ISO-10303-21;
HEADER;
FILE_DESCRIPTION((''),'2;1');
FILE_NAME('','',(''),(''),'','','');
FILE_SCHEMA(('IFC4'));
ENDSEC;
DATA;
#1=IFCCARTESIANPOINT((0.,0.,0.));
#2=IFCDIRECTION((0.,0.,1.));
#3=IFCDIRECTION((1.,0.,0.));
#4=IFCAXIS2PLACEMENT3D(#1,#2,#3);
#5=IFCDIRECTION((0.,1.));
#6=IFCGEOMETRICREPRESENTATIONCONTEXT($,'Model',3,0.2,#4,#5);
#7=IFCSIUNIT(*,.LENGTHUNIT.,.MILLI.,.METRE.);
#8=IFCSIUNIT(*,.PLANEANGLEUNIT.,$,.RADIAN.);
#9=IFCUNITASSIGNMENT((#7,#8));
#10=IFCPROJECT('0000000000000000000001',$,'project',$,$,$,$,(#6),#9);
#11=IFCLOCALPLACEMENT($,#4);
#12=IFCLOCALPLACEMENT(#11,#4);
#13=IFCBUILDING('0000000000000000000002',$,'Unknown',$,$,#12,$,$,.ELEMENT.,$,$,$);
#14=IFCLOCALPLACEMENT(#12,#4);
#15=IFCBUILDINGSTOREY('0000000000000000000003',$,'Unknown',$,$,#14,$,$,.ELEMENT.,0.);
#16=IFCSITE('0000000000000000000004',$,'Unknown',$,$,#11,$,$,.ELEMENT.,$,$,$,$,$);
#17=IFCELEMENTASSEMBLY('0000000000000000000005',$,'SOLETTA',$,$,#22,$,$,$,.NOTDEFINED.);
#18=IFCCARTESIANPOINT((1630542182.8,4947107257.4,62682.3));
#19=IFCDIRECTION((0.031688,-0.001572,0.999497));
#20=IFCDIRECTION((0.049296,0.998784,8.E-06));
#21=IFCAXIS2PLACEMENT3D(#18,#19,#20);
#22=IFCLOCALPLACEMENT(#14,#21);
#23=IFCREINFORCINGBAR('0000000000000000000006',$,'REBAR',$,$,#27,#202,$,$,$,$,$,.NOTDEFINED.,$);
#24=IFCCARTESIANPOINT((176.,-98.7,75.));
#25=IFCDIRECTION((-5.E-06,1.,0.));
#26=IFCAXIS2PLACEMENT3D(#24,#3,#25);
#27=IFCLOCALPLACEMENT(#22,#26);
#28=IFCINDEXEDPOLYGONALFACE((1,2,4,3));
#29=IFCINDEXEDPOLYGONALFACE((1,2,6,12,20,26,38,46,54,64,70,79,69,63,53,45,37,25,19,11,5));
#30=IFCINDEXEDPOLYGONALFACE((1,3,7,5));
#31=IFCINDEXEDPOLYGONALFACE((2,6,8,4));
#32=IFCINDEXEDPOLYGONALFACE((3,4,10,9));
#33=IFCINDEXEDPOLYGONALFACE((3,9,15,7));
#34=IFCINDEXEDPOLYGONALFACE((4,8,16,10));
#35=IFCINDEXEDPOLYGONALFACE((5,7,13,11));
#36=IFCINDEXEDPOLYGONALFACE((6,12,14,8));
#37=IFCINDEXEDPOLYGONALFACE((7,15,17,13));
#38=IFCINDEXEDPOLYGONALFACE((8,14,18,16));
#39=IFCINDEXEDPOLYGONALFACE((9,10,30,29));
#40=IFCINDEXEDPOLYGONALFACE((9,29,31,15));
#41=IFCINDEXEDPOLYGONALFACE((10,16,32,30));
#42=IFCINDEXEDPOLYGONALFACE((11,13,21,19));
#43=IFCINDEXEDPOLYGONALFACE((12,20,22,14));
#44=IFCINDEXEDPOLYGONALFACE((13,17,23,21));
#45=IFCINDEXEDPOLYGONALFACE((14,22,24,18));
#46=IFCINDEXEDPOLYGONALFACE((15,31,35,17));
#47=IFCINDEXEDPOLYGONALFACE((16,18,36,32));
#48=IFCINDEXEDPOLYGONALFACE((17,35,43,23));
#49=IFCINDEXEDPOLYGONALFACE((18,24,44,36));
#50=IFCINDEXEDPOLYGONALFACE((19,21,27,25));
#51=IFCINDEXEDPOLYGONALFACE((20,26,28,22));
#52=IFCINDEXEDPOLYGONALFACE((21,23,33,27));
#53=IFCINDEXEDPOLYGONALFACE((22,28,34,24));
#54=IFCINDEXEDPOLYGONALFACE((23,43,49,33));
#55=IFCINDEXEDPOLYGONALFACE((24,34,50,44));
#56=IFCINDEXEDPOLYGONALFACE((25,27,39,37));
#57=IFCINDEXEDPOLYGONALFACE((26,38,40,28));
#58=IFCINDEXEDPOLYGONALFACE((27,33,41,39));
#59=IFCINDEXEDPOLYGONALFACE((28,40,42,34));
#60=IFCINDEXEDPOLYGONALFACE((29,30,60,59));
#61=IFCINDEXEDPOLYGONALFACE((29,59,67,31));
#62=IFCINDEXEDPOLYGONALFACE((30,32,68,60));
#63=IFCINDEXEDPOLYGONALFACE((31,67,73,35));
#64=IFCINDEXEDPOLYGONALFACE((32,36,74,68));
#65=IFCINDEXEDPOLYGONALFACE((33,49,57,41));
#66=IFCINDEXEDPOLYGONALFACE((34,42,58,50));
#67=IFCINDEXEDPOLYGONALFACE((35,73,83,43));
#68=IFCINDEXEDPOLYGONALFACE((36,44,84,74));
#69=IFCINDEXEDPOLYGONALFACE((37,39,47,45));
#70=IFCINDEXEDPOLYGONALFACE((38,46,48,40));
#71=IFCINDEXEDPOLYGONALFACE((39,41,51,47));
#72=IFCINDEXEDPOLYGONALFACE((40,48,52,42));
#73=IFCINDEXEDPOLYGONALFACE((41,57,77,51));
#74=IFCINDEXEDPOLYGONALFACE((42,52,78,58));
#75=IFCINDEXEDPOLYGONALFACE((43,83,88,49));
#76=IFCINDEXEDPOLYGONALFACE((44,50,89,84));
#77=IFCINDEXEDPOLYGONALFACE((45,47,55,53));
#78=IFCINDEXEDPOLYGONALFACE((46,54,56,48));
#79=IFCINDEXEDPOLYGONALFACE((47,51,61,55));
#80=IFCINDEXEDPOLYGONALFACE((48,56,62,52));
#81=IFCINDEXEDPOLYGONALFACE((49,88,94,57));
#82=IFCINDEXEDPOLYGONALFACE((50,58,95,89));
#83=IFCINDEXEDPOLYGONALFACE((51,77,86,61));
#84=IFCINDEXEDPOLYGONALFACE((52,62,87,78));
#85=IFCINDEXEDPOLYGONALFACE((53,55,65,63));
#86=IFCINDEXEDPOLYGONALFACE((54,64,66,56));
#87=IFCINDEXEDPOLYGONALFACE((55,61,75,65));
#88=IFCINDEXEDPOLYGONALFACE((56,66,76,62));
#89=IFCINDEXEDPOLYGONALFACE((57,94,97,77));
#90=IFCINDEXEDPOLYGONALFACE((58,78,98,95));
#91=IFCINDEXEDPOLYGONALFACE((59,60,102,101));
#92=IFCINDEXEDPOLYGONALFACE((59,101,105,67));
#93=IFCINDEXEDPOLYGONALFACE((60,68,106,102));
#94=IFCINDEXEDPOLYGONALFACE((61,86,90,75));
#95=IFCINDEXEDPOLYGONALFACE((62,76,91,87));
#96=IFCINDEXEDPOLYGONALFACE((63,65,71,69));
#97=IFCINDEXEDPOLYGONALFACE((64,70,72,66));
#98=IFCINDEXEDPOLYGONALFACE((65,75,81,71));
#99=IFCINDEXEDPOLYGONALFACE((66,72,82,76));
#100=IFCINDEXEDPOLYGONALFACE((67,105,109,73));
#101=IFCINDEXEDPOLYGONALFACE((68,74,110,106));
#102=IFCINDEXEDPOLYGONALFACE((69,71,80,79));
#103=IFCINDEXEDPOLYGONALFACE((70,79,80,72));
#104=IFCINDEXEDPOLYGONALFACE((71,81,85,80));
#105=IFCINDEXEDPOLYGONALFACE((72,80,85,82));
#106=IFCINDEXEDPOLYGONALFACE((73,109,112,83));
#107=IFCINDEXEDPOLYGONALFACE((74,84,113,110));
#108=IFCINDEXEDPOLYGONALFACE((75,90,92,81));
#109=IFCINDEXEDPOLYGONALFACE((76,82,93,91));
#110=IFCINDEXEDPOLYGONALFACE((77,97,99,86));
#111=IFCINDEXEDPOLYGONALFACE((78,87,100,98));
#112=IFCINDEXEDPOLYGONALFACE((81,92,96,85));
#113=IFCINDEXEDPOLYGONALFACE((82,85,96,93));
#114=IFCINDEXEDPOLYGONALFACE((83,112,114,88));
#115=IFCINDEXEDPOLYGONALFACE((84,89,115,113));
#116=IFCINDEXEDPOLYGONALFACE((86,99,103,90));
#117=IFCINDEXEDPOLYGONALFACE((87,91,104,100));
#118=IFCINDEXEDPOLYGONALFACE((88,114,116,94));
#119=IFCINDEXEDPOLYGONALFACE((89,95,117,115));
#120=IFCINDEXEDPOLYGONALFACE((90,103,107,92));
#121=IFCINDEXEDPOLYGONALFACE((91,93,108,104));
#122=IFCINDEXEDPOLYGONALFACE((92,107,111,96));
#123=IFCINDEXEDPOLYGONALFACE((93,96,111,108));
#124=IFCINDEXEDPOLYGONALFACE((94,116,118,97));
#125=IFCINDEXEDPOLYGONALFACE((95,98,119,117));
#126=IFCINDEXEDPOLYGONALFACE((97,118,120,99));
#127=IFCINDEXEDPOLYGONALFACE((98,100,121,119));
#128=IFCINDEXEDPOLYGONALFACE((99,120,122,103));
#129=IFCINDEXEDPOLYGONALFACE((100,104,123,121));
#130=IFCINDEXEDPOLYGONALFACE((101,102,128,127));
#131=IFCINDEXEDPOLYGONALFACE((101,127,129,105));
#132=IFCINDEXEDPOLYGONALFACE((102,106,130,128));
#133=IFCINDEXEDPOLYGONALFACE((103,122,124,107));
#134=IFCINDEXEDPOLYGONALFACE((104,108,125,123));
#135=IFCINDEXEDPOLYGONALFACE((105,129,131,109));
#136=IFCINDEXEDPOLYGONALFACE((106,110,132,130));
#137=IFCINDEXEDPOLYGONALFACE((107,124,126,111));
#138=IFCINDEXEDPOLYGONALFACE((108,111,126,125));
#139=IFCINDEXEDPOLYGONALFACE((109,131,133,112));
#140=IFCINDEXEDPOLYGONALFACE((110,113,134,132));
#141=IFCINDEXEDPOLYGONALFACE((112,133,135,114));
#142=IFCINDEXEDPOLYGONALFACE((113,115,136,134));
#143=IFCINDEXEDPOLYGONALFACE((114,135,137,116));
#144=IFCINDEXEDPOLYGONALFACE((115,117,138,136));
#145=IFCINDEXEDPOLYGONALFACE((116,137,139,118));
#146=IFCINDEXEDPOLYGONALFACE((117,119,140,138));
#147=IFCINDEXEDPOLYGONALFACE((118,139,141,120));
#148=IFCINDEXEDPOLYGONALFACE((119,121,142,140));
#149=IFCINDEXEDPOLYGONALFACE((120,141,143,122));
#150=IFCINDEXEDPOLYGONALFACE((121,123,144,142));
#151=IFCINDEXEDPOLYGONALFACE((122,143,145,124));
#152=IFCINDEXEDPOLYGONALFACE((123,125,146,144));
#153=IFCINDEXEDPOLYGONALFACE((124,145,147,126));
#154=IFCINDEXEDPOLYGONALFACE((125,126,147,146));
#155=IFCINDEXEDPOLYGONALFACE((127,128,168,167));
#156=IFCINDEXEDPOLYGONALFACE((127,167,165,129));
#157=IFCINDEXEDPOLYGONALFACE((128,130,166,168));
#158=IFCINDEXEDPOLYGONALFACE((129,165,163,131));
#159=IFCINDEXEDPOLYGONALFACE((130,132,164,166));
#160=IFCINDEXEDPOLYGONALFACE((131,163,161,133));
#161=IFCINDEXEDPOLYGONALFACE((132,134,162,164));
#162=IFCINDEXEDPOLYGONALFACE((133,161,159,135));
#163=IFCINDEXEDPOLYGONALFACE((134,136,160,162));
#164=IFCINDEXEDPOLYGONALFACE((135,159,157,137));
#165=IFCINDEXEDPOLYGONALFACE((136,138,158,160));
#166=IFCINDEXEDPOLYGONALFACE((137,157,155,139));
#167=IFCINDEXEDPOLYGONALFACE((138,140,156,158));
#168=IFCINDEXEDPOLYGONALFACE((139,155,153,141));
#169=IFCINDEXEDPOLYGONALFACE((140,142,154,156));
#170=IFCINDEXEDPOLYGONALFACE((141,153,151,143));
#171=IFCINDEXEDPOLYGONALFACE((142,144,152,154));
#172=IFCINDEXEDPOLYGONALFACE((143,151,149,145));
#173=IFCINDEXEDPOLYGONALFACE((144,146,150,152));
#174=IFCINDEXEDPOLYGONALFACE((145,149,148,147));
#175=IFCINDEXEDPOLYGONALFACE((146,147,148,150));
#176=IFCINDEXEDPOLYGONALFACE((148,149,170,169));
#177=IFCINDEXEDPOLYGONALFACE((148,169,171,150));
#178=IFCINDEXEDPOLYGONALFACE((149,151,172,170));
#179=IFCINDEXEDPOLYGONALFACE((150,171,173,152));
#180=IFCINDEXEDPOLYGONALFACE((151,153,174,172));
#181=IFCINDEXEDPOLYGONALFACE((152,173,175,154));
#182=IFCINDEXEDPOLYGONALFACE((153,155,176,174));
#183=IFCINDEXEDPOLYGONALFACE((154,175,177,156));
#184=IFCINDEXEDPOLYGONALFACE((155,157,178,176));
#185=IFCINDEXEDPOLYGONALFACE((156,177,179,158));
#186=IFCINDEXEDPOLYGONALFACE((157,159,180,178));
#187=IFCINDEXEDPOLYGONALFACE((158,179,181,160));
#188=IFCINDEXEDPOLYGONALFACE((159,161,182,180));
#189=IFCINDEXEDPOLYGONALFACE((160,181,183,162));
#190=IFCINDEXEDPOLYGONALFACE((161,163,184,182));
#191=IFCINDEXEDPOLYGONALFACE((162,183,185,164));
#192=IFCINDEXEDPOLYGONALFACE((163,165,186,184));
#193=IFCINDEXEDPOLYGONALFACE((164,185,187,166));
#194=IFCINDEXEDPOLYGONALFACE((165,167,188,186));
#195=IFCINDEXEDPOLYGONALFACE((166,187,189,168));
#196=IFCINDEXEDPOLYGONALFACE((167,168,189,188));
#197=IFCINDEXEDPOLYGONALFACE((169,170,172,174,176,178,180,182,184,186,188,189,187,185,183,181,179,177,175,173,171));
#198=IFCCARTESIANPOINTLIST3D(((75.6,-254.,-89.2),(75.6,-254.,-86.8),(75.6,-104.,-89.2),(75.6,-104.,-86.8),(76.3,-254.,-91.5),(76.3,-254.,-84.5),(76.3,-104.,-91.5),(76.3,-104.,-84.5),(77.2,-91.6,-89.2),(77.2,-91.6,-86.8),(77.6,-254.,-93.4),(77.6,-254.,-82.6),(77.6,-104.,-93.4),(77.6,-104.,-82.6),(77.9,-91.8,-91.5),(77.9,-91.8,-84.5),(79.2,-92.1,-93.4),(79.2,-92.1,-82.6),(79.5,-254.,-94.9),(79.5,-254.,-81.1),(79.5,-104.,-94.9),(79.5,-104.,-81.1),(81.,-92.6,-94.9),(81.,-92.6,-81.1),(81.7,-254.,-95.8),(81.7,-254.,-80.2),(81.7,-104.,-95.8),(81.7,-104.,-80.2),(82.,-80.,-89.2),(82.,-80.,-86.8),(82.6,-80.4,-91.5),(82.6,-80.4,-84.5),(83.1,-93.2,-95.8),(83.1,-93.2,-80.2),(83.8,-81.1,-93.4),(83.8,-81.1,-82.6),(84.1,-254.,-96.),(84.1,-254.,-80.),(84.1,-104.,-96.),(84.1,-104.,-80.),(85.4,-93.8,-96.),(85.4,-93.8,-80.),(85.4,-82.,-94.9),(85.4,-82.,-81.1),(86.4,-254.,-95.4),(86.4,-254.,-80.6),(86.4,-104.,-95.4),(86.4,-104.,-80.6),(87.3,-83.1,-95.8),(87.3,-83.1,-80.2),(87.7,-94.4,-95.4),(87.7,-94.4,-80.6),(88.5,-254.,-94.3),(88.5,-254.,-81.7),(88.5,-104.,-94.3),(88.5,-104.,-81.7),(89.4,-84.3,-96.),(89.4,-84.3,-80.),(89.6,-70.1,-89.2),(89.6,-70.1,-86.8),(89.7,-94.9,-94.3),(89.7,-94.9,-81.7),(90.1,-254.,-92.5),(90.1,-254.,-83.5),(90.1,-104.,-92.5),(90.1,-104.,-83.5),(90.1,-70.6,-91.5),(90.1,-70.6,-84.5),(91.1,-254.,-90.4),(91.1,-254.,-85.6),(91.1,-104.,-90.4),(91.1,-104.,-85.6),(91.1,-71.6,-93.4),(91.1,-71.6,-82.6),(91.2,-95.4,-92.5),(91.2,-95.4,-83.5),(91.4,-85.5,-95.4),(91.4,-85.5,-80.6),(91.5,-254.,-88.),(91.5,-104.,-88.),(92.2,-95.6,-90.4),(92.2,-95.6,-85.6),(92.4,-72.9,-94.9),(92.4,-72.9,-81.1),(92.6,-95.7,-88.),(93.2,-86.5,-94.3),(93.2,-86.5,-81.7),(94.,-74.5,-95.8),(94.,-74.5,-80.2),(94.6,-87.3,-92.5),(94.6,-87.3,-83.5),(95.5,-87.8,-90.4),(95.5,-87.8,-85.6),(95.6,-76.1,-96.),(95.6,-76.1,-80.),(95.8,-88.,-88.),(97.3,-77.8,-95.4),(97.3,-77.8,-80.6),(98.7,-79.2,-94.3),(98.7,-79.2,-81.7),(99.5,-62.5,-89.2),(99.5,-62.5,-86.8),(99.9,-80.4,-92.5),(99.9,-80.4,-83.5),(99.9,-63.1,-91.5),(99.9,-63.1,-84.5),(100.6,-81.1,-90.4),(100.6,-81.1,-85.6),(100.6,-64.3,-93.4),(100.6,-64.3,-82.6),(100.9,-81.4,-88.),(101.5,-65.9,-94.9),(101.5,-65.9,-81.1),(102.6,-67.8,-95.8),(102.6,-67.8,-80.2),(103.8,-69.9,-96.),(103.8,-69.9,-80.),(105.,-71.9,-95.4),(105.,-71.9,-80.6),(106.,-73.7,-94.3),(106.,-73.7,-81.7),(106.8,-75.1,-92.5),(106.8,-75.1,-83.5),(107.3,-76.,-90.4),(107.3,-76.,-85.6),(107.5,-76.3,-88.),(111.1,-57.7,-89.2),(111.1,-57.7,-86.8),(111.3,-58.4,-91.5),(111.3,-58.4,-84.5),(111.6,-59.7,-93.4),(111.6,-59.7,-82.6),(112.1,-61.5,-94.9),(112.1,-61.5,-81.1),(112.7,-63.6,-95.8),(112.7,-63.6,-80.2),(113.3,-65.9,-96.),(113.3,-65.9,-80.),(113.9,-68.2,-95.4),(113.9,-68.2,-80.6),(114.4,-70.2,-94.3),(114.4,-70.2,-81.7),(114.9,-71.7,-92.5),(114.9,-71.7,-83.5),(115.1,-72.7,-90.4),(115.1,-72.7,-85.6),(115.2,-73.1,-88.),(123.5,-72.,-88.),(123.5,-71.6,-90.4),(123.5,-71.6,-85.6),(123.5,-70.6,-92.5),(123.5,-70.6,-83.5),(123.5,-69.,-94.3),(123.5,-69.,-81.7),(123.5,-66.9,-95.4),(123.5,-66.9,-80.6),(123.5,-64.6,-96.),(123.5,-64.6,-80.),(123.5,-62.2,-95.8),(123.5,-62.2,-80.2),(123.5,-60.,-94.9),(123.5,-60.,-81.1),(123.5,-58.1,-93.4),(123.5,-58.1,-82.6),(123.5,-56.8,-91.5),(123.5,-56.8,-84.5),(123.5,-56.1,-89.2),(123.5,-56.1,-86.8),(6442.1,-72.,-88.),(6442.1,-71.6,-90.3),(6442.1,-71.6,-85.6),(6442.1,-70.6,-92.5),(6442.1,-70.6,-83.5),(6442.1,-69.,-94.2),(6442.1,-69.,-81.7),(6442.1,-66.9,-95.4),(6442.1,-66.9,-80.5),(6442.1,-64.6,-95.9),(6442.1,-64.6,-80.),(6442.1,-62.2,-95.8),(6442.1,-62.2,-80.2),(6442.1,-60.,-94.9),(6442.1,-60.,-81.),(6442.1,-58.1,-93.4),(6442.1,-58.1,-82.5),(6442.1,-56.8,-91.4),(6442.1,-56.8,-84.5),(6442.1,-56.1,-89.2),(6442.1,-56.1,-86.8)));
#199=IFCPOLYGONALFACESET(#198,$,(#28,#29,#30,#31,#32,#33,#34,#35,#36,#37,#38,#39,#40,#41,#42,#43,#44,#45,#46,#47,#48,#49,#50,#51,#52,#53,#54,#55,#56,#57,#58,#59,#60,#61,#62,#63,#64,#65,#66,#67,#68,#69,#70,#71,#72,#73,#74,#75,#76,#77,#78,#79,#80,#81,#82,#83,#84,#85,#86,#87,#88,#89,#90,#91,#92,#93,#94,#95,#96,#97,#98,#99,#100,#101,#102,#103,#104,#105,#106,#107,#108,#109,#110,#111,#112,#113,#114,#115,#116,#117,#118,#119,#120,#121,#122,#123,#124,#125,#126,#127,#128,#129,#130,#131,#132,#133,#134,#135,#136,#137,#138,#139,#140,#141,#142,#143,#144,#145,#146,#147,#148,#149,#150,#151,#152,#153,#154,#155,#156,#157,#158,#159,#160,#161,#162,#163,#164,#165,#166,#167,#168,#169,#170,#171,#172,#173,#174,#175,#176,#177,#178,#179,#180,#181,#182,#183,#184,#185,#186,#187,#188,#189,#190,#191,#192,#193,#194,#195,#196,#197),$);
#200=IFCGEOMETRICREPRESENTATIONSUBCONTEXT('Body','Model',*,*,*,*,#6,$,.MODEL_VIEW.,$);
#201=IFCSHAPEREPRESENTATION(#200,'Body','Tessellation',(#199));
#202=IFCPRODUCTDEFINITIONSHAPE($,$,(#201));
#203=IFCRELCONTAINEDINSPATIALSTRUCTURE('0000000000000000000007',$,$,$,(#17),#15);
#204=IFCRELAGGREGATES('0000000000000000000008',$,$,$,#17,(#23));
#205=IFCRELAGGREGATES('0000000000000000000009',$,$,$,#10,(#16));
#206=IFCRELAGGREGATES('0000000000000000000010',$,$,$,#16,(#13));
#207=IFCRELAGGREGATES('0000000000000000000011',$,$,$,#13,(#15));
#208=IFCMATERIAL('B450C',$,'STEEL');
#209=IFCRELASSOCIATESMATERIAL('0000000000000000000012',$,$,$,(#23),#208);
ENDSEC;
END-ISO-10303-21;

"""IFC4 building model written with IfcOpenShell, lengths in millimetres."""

from ifc_helpers import new_model, entity, si_unit, direction, frame, origin_with_axes, place, context, subcontext, project, spatial, material, element, aggregate, save


model = new_model("IFC4")

# Units and contexts
model_context = context("Model", 3, precision=0.2, world=origin_with_axes(), true_north=direction((0.0, 1.0)))
body_context = subcontext(model_context, "Body", "Model", "MODEL_VIEW")
ifc_project = project(units=[si_unit("LENGTHUNIT", "METRE", prefix="MILLI"), si_unit("PLANEANGLEUNIT", "RADIAN")], contexts=[model_context])

# Site, building, storey
site_placement = place(None, origin_with_axes())
site = spatial("IfcSite", under=ifc_project, at=site_placement, Name="Unknown", CompositionType="ELEMENT")
building_placement = place(site_placement, origin_with_axes())
building = spatial("IfcBuilding", under=site, at=building_placement, Name="Unknown", CompositionType="ELEMENT")
storey_placement = place(building_placement, origin_with_axes())
storey = spatial("IfcBuildingStorey", under=building, at=storey_placement, Name="Unknown", CompositionType="ELEMENT", Elevation=0.0)

# Element assembly, reinforcing bar
ifc_material = material(Name="B450C", Category="STEEL")
assembly_1_placement = place(storey_placement, frame((1630542182.8, 4947107257.4, 62682.3), z_axis=(0.031688, -0.001572, 0.999497), x_axis=(0.049296, 0.998784, 0.000008)))
assembly_1 = element("IfcElementAssembly", 1, at=assembly_1_placement, inside=storey, Name="SOLETTA", PredefinedType="NOTDEFINED")
reinforcing_bar_1_placement = place(assembly_1_placement, frame((176.0, -98.7, 75.0), z_axis=(1.0, 0.0, 0.0), x_axis=(-0.000005, 1.0, 0.0)))
reinforcing_bar_1 = element("IfcReinforcingBar", 2, at=reinforcing_bar_1_placement, material=ifc_material, Name="REBAR", PredefinedType="NOTDEFINED", context=body_context, shape_type="AdvancedSweptSolid", body=[
    entity("IfcSweptDiskSolid", entity("IfcIndexedPolyCurve", entity("IfcCartesianPointList3D", [[83.5, -254.0, -88.0], [83.5, -104.0, -88.0], [95.2, -75.7, -88.0], [123.5, -64.0, -88.0], [6442.1, -64.0, -88.0]]), [entity("IfcLineIndex", [1, 2]), entity("IfcArcIndex", [2, 3, 4]), entity("IfcLineIndex", [4, 5])]), 8.0),
])
aggregate(assembly_1, [reinforcing_bar_1])

save(model, "model.ifc")
